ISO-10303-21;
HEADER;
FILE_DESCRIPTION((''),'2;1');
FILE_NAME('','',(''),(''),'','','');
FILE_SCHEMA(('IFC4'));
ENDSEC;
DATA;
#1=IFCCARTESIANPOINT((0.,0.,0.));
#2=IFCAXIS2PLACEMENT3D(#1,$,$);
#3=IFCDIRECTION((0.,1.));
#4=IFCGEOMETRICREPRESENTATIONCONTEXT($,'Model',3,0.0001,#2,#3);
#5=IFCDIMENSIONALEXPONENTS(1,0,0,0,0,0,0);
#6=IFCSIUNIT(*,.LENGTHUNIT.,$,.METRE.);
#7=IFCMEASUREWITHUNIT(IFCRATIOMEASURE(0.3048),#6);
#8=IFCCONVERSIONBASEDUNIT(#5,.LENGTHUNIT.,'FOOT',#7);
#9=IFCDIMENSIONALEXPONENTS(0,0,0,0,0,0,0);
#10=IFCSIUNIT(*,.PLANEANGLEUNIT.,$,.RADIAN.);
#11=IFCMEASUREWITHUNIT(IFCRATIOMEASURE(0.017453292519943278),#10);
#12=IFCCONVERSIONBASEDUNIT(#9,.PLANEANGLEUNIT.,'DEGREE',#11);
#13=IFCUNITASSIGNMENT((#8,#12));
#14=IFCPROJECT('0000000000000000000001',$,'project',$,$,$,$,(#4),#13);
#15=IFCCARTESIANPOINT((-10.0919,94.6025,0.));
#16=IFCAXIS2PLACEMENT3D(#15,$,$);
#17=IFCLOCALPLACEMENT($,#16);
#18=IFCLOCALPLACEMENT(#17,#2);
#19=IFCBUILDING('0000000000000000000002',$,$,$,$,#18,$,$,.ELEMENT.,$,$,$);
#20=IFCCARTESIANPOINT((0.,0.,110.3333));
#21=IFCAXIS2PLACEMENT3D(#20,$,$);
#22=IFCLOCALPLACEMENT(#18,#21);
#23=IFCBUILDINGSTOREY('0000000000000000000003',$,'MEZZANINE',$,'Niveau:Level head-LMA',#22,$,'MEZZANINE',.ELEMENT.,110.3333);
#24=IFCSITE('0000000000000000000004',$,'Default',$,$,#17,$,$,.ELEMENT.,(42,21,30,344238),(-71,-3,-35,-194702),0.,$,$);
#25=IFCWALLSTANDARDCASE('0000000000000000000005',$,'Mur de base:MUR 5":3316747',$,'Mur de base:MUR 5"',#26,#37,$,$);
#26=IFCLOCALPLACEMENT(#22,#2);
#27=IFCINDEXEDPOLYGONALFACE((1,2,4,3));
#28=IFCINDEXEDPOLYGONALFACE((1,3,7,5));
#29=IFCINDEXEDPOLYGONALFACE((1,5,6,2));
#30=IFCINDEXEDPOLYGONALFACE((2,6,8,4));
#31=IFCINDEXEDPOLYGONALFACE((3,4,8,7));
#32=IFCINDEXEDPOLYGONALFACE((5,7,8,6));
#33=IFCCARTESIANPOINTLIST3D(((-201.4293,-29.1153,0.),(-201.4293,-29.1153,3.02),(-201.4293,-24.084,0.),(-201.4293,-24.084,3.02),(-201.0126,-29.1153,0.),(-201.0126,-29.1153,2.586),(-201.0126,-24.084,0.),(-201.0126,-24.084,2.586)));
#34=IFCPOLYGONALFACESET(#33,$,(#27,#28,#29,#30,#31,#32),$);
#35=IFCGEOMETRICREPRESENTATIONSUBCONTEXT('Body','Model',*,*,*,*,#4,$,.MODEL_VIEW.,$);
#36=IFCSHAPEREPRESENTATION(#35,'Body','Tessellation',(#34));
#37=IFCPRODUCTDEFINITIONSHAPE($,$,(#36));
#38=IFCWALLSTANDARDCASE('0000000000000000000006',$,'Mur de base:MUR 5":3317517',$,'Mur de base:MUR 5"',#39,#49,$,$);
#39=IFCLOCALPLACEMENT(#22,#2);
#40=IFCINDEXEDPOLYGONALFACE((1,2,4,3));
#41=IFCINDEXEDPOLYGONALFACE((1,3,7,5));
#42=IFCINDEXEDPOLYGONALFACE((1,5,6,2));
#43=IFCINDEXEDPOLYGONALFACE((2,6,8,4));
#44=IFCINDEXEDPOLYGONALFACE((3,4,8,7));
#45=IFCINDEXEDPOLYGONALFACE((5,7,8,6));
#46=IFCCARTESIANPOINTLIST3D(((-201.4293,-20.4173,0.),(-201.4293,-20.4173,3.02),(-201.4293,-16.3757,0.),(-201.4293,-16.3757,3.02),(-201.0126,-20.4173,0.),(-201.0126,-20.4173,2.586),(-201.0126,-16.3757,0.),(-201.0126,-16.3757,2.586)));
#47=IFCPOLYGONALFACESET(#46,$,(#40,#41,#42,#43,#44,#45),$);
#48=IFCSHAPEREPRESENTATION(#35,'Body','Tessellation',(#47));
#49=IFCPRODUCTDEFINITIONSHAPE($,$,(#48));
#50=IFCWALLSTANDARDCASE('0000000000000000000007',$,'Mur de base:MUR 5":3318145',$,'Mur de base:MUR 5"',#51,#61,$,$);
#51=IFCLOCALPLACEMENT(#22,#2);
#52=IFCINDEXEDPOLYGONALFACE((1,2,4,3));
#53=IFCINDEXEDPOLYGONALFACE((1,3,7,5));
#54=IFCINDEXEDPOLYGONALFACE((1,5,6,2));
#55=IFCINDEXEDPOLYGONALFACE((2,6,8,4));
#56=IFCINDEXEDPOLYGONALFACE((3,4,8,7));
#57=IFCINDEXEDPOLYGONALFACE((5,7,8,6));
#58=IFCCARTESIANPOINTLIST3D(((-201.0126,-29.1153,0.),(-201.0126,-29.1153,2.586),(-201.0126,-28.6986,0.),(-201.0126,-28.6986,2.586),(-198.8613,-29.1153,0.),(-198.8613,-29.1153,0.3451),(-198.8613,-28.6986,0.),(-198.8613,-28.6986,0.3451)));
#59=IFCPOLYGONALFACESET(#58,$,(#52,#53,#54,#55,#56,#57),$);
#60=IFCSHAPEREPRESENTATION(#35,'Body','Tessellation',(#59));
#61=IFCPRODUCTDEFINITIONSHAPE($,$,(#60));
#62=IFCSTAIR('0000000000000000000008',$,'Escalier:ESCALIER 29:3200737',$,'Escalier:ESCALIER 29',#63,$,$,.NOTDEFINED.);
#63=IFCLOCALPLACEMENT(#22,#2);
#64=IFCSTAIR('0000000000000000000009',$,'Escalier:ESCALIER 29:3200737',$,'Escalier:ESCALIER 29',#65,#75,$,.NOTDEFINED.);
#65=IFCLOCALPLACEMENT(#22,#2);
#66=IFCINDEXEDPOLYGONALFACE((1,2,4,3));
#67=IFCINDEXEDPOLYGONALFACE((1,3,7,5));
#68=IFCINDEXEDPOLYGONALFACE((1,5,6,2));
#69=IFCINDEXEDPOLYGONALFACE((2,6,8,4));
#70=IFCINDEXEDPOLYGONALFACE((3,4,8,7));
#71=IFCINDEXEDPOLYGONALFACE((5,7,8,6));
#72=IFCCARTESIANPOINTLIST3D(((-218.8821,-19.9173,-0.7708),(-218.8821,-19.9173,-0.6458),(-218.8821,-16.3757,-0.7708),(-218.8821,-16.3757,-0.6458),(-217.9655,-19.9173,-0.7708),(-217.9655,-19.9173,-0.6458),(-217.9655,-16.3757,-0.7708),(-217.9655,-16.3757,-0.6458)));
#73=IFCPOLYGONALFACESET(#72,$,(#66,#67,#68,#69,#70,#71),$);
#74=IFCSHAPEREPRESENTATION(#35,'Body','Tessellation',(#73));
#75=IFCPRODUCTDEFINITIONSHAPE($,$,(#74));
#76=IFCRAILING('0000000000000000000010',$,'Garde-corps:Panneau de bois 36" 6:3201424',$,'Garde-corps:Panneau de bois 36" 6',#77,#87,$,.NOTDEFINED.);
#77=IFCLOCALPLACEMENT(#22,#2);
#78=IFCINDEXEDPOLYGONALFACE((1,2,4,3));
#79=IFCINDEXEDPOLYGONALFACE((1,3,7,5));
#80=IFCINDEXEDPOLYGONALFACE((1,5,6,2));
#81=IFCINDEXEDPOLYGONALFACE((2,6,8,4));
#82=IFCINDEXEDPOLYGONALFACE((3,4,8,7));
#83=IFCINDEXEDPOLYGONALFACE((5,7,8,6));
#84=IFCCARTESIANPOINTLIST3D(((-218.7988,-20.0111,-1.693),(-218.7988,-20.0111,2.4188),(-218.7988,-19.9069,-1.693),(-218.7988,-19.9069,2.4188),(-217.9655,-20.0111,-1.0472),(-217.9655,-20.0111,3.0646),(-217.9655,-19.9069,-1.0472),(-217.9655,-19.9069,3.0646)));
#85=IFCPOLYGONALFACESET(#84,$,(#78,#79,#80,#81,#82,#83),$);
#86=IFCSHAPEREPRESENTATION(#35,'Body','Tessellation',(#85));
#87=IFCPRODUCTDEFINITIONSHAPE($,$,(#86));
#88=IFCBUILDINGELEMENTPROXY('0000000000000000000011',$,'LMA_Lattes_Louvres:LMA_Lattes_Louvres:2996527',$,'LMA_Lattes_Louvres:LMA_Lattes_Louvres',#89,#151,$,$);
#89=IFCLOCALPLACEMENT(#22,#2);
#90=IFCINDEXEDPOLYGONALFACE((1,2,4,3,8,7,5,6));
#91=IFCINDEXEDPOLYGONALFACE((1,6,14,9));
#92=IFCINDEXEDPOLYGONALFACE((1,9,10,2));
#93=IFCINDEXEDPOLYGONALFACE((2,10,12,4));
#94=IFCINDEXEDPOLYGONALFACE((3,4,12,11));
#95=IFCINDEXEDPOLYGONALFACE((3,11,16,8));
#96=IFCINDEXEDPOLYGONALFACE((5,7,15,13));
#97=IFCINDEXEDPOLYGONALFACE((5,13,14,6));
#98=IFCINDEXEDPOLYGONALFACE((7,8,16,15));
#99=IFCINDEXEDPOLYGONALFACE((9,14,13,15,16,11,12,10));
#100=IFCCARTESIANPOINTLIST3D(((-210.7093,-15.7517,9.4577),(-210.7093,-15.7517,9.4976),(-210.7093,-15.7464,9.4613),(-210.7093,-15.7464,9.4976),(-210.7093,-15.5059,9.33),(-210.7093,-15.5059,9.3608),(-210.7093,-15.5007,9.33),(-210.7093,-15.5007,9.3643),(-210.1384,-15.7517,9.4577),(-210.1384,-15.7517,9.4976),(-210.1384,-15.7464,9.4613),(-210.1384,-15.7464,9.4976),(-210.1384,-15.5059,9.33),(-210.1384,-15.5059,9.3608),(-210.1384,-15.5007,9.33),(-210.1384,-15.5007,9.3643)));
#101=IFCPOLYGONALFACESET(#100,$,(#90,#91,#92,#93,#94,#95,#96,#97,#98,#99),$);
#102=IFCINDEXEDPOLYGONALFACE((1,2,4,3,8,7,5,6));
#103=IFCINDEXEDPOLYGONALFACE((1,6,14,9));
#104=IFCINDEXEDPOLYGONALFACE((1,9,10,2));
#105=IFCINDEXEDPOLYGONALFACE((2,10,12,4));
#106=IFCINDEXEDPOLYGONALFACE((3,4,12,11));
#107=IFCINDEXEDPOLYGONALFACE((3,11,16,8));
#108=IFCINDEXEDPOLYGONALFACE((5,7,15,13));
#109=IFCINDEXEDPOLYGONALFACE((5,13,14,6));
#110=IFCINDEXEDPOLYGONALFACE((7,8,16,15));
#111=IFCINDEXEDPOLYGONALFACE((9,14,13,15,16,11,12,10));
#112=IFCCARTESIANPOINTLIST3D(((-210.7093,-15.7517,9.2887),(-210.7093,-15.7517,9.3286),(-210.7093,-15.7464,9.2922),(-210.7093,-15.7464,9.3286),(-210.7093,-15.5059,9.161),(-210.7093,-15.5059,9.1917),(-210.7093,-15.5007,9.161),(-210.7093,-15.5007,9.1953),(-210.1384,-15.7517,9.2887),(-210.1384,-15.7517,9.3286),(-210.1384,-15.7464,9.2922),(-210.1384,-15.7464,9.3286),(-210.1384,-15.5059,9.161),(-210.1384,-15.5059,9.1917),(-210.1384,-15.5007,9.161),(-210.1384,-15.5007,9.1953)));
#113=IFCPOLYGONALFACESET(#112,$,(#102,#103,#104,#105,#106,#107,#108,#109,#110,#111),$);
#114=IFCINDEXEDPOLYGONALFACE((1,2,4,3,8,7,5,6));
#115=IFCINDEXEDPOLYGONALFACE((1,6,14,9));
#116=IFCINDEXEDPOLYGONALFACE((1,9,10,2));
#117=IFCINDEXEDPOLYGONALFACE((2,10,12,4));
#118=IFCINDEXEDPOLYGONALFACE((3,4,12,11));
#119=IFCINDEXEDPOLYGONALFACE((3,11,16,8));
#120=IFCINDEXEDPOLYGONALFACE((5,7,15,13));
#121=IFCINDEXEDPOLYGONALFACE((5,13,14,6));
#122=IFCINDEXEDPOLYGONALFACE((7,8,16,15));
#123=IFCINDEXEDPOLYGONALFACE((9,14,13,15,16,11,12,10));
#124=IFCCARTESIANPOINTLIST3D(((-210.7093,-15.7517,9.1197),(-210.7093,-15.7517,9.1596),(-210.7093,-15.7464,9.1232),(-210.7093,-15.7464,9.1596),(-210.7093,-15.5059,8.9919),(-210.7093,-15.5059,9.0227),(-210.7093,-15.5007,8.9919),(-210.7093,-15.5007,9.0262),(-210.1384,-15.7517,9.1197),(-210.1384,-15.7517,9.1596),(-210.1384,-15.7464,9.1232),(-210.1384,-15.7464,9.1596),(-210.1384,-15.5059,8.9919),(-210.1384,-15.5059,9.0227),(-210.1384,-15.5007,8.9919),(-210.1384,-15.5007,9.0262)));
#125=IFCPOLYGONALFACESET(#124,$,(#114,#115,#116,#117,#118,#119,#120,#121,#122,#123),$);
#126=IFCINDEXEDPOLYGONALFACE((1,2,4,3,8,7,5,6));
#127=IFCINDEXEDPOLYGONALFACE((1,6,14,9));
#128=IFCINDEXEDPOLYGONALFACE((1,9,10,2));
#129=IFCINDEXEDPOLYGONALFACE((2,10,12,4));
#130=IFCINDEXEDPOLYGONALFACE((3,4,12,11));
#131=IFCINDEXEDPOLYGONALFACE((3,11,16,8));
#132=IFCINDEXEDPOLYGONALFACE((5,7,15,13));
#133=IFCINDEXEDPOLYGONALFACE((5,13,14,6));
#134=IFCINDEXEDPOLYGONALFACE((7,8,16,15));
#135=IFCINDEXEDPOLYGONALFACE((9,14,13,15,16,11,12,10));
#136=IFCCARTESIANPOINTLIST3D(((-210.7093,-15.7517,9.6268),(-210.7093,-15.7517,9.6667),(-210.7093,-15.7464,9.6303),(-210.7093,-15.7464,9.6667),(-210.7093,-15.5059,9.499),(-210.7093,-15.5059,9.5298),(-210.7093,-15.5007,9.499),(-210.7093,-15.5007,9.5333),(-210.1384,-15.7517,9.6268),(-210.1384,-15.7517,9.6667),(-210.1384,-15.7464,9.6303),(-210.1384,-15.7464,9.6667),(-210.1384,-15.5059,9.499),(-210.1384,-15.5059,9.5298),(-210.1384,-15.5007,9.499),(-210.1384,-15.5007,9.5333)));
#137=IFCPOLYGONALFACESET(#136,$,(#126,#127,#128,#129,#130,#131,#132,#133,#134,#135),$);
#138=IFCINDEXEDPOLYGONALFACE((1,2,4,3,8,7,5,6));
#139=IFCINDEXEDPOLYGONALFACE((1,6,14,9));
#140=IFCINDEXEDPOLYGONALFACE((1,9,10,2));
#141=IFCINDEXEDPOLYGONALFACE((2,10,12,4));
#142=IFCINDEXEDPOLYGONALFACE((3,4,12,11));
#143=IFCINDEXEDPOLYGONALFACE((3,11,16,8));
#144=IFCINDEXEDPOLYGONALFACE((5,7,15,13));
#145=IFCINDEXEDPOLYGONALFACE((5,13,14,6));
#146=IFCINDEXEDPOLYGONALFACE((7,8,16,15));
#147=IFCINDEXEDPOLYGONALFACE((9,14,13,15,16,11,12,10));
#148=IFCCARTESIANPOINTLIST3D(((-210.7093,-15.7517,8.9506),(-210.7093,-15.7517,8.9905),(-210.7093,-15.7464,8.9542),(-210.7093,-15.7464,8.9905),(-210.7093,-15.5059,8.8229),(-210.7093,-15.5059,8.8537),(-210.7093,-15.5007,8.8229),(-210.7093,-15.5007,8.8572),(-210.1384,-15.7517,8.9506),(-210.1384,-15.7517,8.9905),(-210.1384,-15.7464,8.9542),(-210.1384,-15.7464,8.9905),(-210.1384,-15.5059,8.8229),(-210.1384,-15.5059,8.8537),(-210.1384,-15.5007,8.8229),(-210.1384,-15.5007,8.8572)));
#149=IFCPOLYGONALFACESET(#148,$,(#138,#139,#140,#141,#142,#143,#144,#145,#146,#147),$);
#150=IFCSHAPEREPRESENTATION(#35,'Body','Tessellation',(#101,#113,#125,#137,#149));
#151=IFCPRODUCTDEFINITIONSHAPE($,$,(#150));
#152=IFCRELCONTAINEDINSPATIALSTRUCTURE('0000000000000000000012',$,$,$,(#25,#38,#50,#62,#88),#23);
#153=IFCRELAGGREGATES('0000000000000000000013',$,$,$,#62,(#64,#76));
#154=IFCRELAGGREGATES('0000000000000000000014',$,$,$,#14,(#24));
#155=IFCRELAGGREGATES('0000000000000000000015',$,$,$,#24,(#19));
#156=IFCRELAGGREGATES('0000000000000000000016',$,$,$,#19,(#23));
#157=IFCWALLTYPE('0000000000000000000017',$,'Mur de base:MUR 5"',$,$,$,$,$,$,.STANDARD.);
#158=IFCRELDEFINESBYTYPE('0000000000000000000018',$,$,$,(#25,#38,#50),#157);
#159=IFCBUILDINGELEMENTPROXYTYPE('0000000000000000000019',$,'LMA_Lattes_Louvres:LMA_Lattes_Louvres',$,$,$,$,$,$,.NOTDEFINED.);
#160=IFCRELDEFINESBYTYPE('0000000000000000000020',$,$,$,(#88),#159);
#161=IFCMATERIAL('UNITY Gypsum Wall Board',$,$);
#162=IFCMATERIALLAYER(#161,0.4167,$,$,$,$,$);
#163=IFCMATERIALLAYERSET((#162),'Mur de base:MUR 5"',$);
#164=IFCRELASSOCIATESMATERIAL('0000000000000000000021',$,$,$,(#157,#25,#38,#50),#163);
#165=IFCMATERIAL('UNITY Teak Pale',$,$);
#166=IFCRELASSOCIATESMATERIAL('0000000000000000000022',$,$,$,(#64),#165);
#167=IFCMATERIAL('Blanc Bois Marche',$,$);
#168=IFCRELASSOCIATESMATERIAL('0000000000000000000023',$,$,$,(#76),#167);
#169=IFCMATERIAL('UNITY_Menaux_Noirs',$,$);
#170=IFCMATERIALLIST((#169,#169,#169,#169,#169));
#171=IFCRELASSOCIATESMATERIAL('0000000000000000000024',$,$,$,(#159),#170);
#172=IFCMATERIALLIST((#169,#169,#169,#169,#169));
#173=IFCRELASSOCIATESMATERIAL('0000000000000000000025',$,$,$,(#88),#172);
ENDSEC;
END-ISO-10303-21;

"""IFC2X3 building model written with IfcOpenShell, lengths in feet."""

from ifc_helpers import new_model, entity, si_unit, converted_unit, direction, frame, frame_2d, origin, place, context, subcontext, project, spatial, polyline, rectangle, outline, extrude, clip, bounded_halfspace, source, transform, mapped, material, material_list, layer, layer_set, layer_usage, type_object, type_shapes, element, aggregate, save


model = new_model("IFC2X3")

# Units and contexts
model_context = context("Model", 3, precision=0.0001, world=origin(), true_north=direction((0.0, 1.0)))
body_context = subcontext(model_context, "Body", "Model", "MODEL_VIEW")
ifc_project = project(units=[converted_unit("LENGTHUNIT", "FOOT", entity("IfcRatioMeasure", 0.3048), si_unit("LENGTHUNIT", "METRE"), dimensions=[1, 0, 0, 0, 0, 0, 0]), converted_unit("PLANEANGLEUNIT", "DEGREE", entity("IfcRatioMeasure", 0.017453292519943278), si_unit("PLANEANGLEUNIT", "RADIAN"), dimensions=[0, 0, 0, 0, 0, 0, 0])], contexts=[model_context])

# Site, building, storey
site_placement = place(None, frame((-10.0919, 94.6025, 0.0)))
site = spatial("IfcSite", under=ifc_project, at=site_placement, Name="Default", CompositionType="ELEMENT", RefLatitude=(42, 21, 30, 344238), RefLongitude=(-71, -3, -35, -194702), RefElevation=0.0)
building_placement = place(site_placement, origin())
building = spatial("IfcBuilding", under=site, at=building_placement, CompositionType="ELEMENT")
storey_placement = place(building_placement, frame((0.0, 0.0, 110.3333)))
storey = spatial("IfcBuildingStorey", under=building, at=storey_placement, Name="MEZZANINE", ObjectType="Niveau:Level head-LMA", LongName="MEZZANINE", CompositionType="ELEMENT", Elevation=110.3333)

# Shared definitions
ifc_material_1 = material(Name="UNITY Gypsum Wall Board")
ifc_layer_1 = layer(ifc_material_1, 0.4167)
ifc_layer_set_1 = layer_set([ifc_layer_1], Name="Mur de base:MUR 5\"")
wall_type_1 = type_object("IfcWallType", Name="Mur de base:MUR 5\"", PredefinedType="STANDARD", material=ifc_layer_set_1)

# Walls
ifc_layer_usage_1 = layer_usage(ifc_layer_set_1, "AXIS2", "NEGATIVE", 0.2083)
wall_1_placement = place(storey_placement, frame((-201.2209, -29.1153, 0.0), z_axis=(0.0, 0.0, 1.0), x_axis=(0.0, 1.0, 0.0)))
element("IfcWallStandardCase", 1, at=wall_1_placement, inside=storey, type_object=wall_type_1, material=ifc_layer_usage_1, Name="Mur de base:MUR 5\":3316747", ObjectType="Mur de base:MUR 5\"", context=body_context, shape_type="Clipping", body=[
    clip(extrude(rectangle(XDim=5.0312, YDim=0.4167, at=frame_2d((2.5156, 0.0), x_axis=(-1.0, 0.0))), origin(), (0.0, 0.0, 1.0), 3.02), bounded_halfspace(frame((0.0, -0.2083, 2.586), z_axis=(0.0, -0.721387, 0.692532), x_axis=(1.0, 0.0, 0.0)), False, frame((0.0, -0.2083, 2.586)), polyline([(0.0, 0.0), (0.4167, 0.0), (5.0312, 0.0), (5.0312, 0.4167), (0.0, 0.4167), (0.0, 0.0)]))),
])
ifc_layer_usage_2 = layer_usage(ifc_layer_set_1, "AXIS2", "NEGATIVE", 0.2083)
wall_2_placement = place(storey_placement, frame((-201.2209, -20.4173, 0.0), z_axis=(0.0, 0.0, 1.0), x_axis=(0.0, 1.0, 0.0)))
element("IfcWallStandardCase", 2, at=wall_2_placement, inside=storey, type_object=wall_type_1, material=ifc_layer_usage_2, Name="Mur de base:MUR 5\":3317517", ObjectType="Mur de base:MUR 5\"", context=body_context, shape_type="Clipping", body=[
    clip(extrude(rectangle(XDim=4.0417, YDim=0.4167, at=frame_2d((2.0208, 0.0), x_axis=(-1.0, 0.0))), origin(), (0.0, 0.0, 1.0), 3.02), bounded_halfspace(frame((0.0, -0.2083, 2.586), z_axis=(0.0, -0.721387, 0.692532), x_axis=(1.0, 0.0, 0.0)), False, frame((0.0, -0.2083, 2.586)), polyline([(0.0, 0.0), (4.0417, 0.0), (4.0417, 0.4167), (0.0, 0.4167), (0.0, 0.0)]))),
])

# Wall
ifc_layer_usage_3 = layer_usage(ifc_layer_set_1, "AXIS2", "NEGATIVE", 0.2083)
wall_3_placement = place(storey_placement, frame((-198.8613, -28.9069, 0.0), z_axis=(0.0, 0.0, 1.0), x_axis=(-1.0, 0.0, 0.0)))
element("IfcWallStandardCase", 3, at=wall_3_placement, inside=storey, type_object=wall_type_1, material=ifc_layer_usage_3, Name="Mur de base:MUR 5\":3318145", ObjectType="Mur de base:MUR 5\"", context=body_context, shape_type="Clipping", body=[
    clip(extrude(rectangle(XDim=2.1513, YDim=0.4167, at=frame_2d((1.0756, 0.0), x_axis=(-1.0, 0.0))), origin(), (0.0, 0.0, 1.0), 2.586), bounded_halfspace(frame((0.0, -0.2083, 0.3451), z_axis=(-0.721387, 0.0, 0.692532), x_axis=(0.0, -1.0, 0.0)), False, frame((0.0, -0.2083, 0.3451)), polyline([(0.0, 0.0), (2.1513, 0.0), (2.1513, 0.4167), (0.0, 0.4167), (0.0, 0.0)]))),
])

# Stairs
stair_1_placement = place(storey_placement, origin())
stair_1 = element("IfcStair", 4, at=stair_1_placement, inside=storey, Name="Escalier:ESCALIER 29:3200737", ObjectType="Escalier:ESCALIER 29", ShapeType="NOTDEFINED")
ifc_material_2 = material(Name="UNITY Teak Pale")
stair_2_placement = place(stair_1_placement, origin())
stair_2 = element("IfcStair", 5, at=stair_2_placement, material=ifc_material_2, Name="Escalier:ESCALIER 29:3200737", ObjectType="Escalier:ESCALIER 29", ShapeType="NOTDEFINED", context=body_context, shape_type="SweptSolid", body=[
    extrude(rectangle(XDim=0.9167, YDim=3.5417, at=frame_2d((0.0, 0.0), x_axis=(1.0, 0.0))), frame((-218.4238, -18.1465, -0.7708), z_axis=(0.0, 0.0, 1.0), x_axis=(-1.0, 0.0, 0.0)), (0.0, 0.0, 1.0), 0.125),
])

# Railing
ifc_material_3 = material(Name="Blanc Bois Marche")
railing_1_placement = place(stair_1_placement, frame((0.0, 0.0, -1.0)))
railing_1 = element("IfcRailing", 6, at=railing_1_placement, material=ifc_material_3, Name="Garde-corps:Panneau de bois 36\" 6:3201424", ObjectType="Garde-corps:Panneau de bois 36\" 6", PredefinedType="NOTDEFINED", context=body_context, shape_type="SweptSolid", body=[
    extrude(outline(polyline([(0.7322, -1.625), (1.7865, -1.625), (-0.7322, 1.625), (-1.7865, 1.625), (0.7322, -1.625)])), frame((-218.3821, -20.0111, 1.6858), z_axis=(0.0, 1.0, 0.0), x_axis=(0.790415, 0.0, 0.612572)), (0.0, 0.0, 1.0), 0.1042),
])
aggregate(stair_1, [stair_2, railing_1])

# Building element proxy
ifc_material_4 = material(Name="UNITY_Menaux_Noirs")
ifc_material_list_1 = material_list([ifc_material_4, ifc_material_4, ifc_material_4, ifc_material_4, ifc_material_4])
ifc_material_list_2 = material_list([ifc_material_4, ifc_material_4, ifc_material_4, ifc_material_4, ifc_material_4])
building_element_proxy_type = type_object("IfcBuildingElementProxyType", Name="LMA_Lattes_Louvres:LMA_Lattes_Louvres", PredefinedType="NOTDEFINED", material=ifc_material_list_2)
shared_shape_1 = source(origin(), body_context, "Body", "SweptSolid", [
    extrude(outline(polyline([(-0.1298, -0.0013), (0.1344, -0.0013), (0.147, 0.0306), (0.1421, 0.0325), (0.1308, 0.0039), (-0.1334, 0.0039), (-0.148, -0.0332), (-0.1432, -0.0351), (-0.1298, -0.0013)])), frame((-0.2854, -0.1255, 0.5895), z_axis=(1.0, 0.0, 0.0), x_axis=(0.0, -0.930221, -0.367)), (0.0, 0.0, 1.0), 0.5709),
    extrude(outline(polyline([(-0.1298, -0.0013), (0.1344, -0.0013), (0.147, 0.0306), (0.1421, 0.0325), (0.1308, 0.0039), (-0.1334, 0.0039), (-0.148, -0.0332), (-0.1432, -0.0351), (-0.1298, -0.0013)])), frame((-0.2854, -0.1255, 0.4205), z_axis=(1.0, 0.0, 0.0), x_axis=(0.0, -0.930221, -0.367)), (0.0, 0.0, 1.0), 0.5709),
    extrude(outline(polyline([(-0.1298, -0.0013), (0.1344, -0.0013), (0.147, 0.0306), (0.1421, 0.0325), (0.1308, 0.0039), (-0.1334, 0.0039), (-0.148, -0.0332), (-0.1432, -0.0351), (-0.1298, -0.0013)])), frame((-0.2854, -0.1255, 0.2514), z_axis=(1.0, 0.0, 0.0), x_axis=(0.0, -0.930221, -0.367)), (0.0, 0.0, 1.0), 0.5709),
    extrude(outline(polyline([(-0.1298, -0.0013), (0.1344, -0.0013), (0.147, 0.0306), (0.1421, 0.0325), (0.1308, 0.0039), (-0.1334, 0.0039), (-0.148, -0.0332), (-0.1432, -0.0351), (-0.1298, -0.0013)])), frame((-0.2854, -0.1255, 0.7585), z_axis=(1.0, 0.0, 0.0), x_axis=(0.0, -0.930221, -0.367)), (0.0, 0.0, 1.0), 0.5709),
    extrude(outline(polyline([(-0.1298, -0.0013), (0.1344, -0.0013), (0.147, 0.0306), (0.1421, 0.0325), (0.1308, 0.0039), (-0.1334, 0.0039), (-0.148, -0.0332), (-0.1432, -0.0351), (-0.1298, -0.0013)])), frame((-0.2854, -0.1255, 0.0824), z_axis=(1.0, 0.0, 0.0), x_axis=(0.0, -0.930221, -0.367)), (0.0, 0.0, 1.0), 0.5709),
])
type_shapes(building_element_proxy_type, [shared_shape_1])
proxy_placement = place(storey_placement, frame((-210.4238, -15.7517, 8.8229), z_axis=(0.0, 0.0, 1.0), x_axis=(-1.0, 0.0, 0.0)))
element("IfcBuildingElementProxy", 7, at=proxy_placement, inside=storey, type_object=building_element_proxy_type, material=ifc_material_list_1, Name="LMA_Lattes_Louvres:LMA_Lattes_Louvres:2996527", ObjectType="LMA_Lattes_Louvres:LMA_Lattes_Louvres", context=body_context, shape_type="MappedRepresentation", body=[
    mapped(shared_shape_1, transform((0.0, 0.0, 0.0), scale=1.0)),
])

save(model, "model.ifc")
